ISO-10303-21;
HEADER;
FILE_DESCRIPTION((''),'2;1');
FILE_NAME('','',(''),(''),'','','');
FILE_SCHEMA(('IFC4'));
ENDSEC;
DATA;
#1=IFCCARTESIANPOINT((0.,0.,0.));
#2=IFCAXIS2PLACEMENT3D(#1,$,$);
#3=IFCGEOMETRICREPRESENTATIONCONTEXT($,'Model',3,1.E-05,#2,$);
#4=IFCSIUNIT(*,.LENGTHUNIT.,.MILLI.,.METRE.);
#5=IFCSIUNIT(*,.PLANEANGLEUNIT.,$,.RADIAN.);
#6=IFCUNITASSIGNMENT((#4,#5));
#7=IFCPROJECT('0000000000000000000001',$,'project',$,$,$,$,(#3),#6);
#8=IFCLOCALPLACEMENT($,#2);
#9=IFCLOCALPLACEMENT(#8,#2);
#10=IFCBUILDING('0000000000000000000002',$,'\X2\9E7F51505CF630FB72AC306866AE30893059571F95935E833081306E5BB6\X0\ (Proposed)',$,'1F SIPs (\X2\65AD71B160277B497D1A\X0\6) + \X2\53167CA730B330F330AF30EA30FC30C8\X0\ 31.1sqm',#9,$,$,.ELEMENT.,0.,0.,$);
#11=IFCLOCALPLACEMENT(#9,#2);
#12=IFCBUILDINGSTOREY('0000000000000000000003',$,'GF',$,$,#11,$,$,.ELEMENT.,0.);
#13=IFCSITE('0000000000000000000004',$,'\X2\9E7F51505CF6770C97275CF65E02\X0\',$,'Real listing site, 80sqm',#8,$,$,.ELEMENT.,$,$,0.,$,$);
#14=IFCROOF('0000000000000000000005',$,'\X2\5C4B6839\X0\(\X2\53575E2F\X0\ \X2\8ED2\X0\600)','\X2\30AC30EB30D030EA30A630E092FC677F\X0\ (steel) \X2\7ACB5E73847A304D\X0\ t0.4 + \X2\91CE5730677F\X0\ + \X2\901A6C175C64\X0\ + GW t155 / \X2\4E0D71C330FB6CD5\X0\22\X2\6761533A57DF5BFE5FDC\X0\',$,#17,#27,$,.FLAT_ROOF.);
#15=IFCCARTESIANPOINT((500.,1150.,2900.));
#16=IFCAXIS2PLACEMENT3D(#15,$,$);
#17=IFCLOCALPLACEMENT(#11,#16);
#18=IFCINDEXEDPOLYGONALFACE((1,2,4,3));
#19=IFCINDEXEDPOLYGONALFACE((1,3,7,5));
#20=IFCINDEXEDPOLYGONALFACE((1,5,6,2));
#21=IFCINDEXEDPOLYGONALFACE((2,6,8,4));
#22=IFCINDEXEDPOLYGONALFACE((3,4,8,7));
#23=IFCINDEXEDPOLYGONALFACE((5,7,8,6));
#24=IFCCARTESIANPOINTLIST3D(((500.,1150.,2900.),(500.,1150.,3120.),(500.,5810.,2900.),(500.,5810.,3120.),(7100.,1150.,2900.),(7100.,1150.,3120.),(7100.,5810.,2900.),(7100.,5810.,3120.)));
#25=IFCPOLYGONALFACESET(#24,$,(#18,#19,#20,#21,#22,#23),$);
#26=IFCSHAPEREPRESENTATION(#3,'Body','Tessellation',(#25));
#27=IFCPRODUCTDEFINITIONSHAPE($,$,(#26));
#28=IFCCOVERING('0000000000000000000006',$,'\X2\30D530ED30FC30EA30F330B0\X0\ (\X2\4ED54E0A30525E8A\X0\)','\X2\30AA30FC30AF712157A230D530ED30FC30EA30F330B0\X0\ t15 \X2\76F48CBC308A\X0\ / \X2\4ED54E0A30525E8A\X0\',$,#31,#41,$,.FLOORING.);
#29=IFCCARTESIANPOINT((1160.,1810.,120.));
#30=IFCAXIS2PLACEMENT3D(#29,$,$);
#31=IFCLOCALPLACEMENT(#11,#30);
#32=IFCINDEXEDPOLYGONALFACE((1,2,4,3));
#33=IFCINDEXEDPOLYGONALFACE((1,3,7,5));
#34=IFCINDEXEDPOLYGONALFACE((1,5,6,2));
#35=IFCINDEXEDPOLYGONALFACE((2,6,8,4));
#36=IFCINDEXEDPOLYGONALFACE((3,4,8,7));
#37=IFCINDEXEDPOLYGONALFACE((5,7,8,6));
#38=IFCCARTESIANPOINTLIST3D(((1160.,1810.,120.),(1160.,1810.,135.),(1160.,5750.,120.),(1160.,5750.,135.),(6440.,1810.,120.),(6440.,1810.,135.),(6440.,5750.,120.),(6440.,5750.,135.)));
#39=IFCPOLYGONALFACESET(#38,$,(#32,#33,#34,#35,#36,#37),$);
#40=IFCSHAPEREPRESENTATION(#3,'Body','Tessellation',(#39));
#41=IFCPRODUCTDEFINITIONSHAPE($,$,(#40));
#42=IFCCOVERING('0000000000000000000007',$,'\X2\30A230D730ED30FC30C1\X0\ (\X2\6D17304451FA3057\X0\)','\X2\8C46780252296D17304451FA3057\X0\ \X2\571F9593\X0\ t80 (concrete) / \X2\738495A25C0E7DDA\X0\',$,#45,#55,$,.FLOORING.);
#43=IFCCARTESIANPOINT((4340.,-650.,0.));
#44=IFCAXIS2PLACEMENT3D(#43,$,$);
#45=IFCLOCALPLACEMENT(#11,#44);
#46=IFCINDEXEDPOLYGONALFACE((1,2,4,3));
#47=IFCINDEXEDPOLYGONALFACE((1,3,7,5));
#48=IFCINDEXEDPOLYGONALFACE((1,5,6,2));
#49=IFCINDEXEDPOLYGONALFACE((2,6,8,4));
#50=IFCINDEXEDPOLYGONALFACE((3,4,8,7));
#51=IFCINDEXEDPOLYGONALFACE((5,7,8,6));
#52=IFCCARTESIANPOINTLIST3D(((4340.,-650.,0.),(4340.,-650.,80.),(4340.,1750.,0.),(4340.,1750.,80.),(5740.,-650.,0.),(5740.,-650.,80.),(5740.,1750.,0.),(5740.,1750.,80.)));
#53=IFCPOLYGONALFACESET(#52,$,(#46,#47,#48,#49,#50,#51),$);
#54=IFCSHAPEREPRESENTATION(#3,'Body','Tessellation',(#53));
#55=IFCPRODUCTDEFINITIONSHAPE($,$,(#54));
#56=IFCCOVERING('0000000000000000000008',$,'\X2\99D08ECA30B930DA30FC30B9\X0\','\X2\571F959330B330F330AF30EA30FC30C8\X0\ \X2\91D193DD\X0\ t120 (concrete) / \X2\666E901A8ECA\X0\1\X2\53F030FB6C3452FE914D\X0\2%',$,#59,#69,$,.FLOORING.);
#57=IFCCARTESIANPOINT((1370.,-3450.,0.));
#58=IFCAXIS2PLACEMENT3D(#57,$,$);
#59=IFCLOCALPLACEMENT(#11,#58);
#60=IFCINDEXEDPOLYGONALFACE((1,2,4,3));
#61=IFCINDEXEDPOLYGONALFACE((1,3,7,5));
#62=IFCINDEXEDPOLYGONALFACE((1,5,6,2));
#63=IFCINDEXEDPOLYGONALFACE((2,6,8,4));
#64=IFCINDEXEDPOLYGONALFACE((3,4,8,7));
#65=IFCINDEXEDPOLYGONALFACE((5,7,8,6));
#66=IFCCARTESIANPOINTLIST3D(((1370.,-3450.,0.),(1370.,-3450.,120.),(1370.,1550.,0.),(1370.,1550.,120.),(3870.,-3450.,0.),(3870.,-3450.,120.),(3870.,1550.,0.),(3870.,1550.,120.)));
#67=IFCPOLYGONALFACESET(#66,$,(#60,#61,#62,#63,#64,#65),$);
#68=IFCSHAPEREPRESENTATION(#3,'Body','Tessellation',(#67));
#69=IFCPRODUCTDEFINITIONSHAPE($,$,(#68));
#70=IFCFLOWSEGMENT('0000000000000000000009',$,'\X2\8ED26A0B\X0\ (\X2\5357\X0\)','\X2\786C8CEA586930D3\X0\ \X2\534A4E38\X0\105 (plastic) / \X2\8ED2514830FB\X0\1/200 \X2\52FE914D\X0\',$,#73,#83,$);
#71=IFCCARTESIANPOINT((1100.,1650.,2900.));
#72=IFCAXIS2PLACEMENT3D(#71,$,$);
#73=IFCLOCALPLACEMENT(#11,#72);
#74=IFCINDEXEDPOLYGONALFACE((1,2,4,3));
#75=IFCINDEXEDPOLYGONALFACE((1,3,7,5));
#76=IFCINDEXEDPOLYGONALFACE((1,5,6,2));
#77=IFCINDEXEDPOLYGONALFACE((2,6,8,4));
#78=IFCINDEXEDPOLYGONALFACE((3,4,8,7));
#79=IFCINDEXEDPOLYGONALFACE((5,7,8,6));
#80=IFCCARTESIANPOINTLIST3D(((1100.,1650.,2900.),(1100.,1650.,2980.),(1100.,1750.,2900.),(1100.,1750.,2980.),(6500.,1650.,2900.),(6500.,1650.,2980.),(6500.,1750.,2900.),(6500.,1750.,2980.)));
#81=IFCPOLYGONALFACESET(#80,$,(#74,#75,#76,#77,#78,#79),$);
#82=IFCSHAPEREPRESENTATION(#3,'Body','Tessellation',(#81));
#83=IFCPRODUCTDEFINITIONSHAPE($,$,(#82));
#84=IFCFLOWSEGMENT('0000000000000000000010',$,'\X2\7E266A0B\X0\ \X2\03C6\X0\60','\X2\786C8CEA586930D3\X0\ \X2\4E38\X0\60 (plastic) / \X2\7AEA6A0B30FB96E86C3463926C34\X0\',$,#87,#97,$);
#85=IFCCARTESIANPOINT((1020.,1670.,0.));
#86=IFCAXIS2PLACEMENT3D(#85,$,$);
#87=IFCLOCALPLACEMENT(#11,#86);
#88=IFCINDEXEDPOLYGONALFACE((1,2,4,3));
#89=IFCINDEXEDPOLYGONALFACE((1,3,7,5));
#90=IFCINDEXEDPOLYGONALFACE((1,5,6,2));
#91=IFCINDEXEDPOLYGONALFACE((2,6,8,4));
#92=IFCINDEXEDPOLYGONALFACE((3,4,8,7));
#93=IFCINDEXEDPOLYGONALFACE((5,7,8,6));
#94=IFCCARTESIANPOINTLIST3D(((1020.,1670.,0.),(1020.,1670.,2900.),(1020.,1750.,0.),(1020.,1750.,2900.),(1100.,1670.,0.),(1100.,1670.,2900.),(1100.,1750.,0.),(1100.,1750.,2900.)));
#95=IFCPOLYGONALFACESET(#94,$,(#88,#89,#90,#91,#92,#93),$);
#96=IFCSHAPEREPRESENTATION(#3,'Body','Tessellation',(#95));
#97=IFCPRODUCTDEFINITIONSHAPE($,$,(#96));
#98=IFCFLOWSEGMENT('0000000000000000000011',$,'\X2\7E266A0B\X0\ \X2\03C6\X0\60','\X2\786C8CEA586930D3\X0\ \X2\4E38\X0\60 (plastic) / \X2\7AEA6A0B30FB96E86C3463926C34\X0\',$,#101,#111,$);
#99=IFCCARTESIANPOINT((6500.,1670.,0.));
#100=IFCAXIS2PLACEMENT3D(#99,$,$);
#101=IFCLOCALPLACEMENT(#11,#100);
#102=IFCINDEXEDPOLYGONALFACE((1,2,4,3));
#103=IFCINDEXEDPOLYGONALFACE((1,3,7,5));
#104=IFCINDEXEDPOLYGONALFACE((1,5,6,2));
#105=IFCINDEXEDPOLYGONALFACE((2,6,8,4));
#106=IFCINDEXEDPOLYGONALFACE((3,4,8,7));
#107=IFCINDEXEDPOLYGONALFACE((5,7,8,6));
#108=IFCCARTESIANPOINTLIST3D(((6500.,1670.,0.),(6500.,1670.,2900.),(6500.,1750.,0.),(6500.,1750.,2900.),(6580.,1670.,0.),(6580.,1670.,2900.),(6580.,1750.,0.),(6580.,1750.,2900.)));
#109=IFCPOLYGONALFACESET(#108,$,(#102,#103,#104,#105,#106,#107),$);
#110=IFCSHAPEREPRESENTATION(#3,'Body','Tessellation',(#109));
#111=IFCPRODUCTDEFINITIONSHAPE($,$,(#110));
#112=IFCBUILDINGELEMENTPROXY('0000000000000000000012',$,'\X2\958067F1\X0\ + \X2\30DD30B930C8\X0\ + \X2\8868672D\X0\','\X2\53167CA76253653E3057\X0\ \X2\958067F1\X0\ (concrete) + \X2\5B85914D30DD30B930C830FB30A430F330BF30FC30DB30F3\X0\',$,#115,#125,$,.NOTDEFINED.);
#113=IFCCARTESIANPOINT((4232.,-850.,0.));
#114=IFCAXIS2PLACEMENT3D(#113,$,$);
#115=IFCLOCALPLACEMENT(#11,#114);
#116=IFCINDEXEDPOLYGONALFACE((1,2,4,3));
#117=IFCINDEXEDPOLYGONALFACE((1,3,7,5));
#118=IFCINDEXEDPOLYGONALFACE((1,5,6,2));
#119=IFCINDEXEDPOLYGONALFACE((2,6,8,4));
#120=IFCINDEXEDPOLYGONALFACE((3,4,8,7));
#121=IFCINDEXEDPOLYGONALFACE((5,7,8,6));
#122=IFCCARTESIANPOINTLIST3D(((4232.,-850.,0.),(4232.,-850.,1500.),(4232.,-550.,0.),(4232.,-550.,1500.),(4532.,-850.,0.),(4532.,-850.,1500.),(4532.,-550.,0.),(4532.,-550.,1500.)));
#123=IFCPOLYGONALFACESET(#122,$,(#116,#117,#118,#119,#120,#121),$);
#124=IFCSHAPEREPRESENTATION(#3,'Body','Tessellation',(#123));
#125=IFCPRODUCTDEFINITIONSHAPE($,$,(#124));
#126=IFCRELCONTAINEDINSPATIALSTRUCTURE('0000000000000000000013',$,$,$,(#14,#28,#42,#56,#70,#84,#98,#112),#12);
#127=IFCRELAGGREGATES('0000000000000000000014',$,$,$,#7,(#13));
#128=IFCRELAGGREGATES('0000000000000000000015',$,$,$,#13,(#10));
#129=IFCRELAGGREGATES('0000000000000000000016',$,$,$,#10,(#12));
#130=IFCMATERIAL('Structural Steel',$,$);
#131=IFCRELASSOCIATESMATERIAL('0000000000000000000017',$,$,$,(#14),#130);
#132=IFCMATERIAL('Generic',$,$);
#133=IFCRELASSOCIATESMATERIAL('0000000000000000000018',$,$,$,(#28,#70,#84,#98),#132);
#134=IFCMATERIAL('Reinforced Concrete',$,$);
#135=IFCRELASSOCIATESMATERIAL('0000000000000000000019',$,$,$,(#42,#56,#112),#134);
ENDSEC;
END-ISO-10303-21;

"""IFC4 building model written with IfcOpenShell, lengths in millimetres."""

from ifc_helpers import new_model, si_unit, frame, frame_2d, origin, place, context, project, spatial, rectangle, extrude, material, element, save


model = new_model("IFC4")

# Units and contexts
model_context = context("Model", 3, precision=1e-05, world=origin())
ifc_project = project(units=[si_unit("LENGTHUNIT", "METRE", prefix="MILLI"), si_unit("PLANEANGLEUNIT", "RADIAN")], contexts=[model_context])

# Site, building, storey
site_placement = place(None, origin())
site = spatial("IfcSite", under=ifc_project, at=site_placement, Name="鹿児島県霧島市", ObjectType="Real listing site, 80sqm", CompositionType="ELEMENT", RefElevation=0.0)
building_placement = place(site_placement, origin())
building = spatial("IfcBuilding", under=site, at=building_placement, Name="鹿児島・犬と暮らす土間広めの家 (Proposed)", ObjectType="1F SIPs (断熱性等級6) + 化粧コンクリート 31.1sqm", CompositionType="ELEMENT", ElevationOfRefHeight=0.0, ElevationOfTerrain=0.0)
storey_placement = place(building_placement, origin())
storey = spatial("IfcBuildingStorey", under=building, at=storey_placement, Name="GF", CompositionType="ELEMENT", Elevation=0.0)

# Shared definitions
ifc_material_1 = material(Name="Reinforced Concrete")

# Roof
ifc_material_2 = material(Name="Structural Steel")
roof_placement = place(storey_placement, frame((500.0, 1150.0, 2900.0)))
element("IfcRoof", 1, at=roof_placement, inside=storey, material=ifc_material_2, Name="屋根(南帯 軒600)", Description="ガルバリウム鋼板 (steel) 立平葺き t0.4 + 野地板 + 通気層 + GW t155 / 不燃・法22条区域対応", PredefinedType="FLAT_ROOF", context=model_context, shape_type="SweptSolid", body=[
    extrude(rectangle(XDim=6600.0, YDim=4660.0, at=frame_2d((3300.0, 2330.0))), frame((500.0, 1150.0, 2900.0)), (0.0, 0.0, 1.0), 220.0),
])

# Coverings
ifc_material_3 = material(Name="Generic")
covering_1_placement = place(storey_placement, frame((1160.0, 1810.0, 120.0)))
element("IfcCovering", 2, at=covering_1_placement, inside=storey, material=ifc_material_3, Name="フローリング (仕上げ床)", Description="オーク無垢フローリング t15 直貼り / 仕上げ床", PredefinedType="FLOORING", context=model_context, shape_type="SweptSolid", body=[
    extrude(rectangle(XDim=5280.0, YDim=3940.0, at=frame_2d((2640.0, 1970.0))), frame((1160.0, 1810.0, 120.0)), (0.0, 0.0, 1.0), 15.0),
])
covering_2_placement = place(storey_placement, frame((4340.0, -650.0, 0.0)))
element("IfcCovering", 3, at=covering_2_placement, inside=storey, material=ifc_material_1, Name="アプローチ (洗い出し)", Description="豆砂利洗い出し 土間 t80 (concrete) / 玄関導線", PredefinedType="FLOORING", context=model_context, shape_type="SweptSolid", body=[
    extrude(rectangle(XDim=1400.0, YDim=2400.0, at=frame_2d((700.0, 1200.0))), frame((4340.0, -650.0, 0.0)), (0.0, 0.0, 1.0), 80.0),
])
covering_3_placement = place(storey_placement, frame((1370.0, -3450.0, 0.0)))
element("IfcCovering", 4, at=covering_3_placement, inside=storey, material=ifc_material_1, Name="駐車スペース", Description="土間コンクリート 金鏝 t120 (concrete) / 普通車1台・水勾配2%", PredefinedType="FLOORING", context=model_context, shape_type="SweptSolid", body=[
    extrude(rectangle(XDim=2500.0, YDim=5000.0, at=frame_2d((1250.0, 2500.0))), frame((1370.0, -3450.0, 0.0)), (0.0, 0.0, 1.0), 120.0),
])

# Flow segments
flow_segment_1_placement = place(storey_placement, frame((1100.0, 1650.0, 2900.0)))
element("IfcFlowSegment", 5, at=flow_segment_1_placement, inside=storey, material=ifc_material_3, Name="軒樋 (南)", Description="硬質塩ビ 半丸105 (plastic) / 軒先・1/200 勾配", context=model_context, shape_type="SweptSolid", body=[
    extrude(rectangle(XDim=5400.0, YDim=100.0, at=frame_2d((2700.0, 50.0))), frame((1100.0, 1650.0, 2900.0)), (0.0, 0.0, 1.0), 80.0),
])
flow_segment_2_placement = place(storey_placement, frame((1020.0, 1670.0, 0.0)))
element("IfcFlowSegment", 6, at=flow_segment_2_placement, inside=storey, material=ifc_material_3, Name="縦樋 φ60", Description="硬質塩ビ 丸60 (plastic) / 竪樋・雨水排水", context=model_context, shape_type="SweptSolid", body=[
    extrude(rectangle(XDim=80.0, YDim=80.0, at=frame_2d((40.0, 40.0))), frame((1020.0, 1670.0, 0.0)), (0.0, 0.0, 1.0), 2900.0),
])
flow_segment_3_placement = place(storey_placement, frame((6500.0, 1670.0, 0.0)))
element("IfcFlowSegment", 7, at=flow_segment_3_placement, inside=storey, material=ifc_material_3, Name="縦樋 φ60", Description="硬質塩ビ 丸60 (plastic) / 竪樋・雨水排水", context=model_context, shape_type="SweptSolid", body=[
    extrude(rectangle(XDim=80.0, YDim=80.0, at=frame_2d((40.0, 40.0))), frame((6500.0, 1670.0, 0.0)), (0.0, 0.0, 1.0), 2900.0),
])

# Building element proxy
proxy_placement = place(storey_placement, frame((4232.0, -850.0, 0.0)))
element("IfcBuildingElementProxy", 8, at=proxy_placement, inside=storey, material=ifc_material_1, Name="門柱 + ポスト + 表札", Description="化粧打放し 門柱 (concrete) + 宅配ポスト・インターホン", PredefinedType="NOTDEFINED", context=model_context, shape_type="SweptSolid", body=[
    extrude(rectangle(XDim=300.0, YDim=300.0, at=frame_2d((150.0, 150.0))), frame((4232.0, -850.0, 0.0)), (0.0, 0.0, 1.0), 1500.0),
])

save(model, "model.ifc")
